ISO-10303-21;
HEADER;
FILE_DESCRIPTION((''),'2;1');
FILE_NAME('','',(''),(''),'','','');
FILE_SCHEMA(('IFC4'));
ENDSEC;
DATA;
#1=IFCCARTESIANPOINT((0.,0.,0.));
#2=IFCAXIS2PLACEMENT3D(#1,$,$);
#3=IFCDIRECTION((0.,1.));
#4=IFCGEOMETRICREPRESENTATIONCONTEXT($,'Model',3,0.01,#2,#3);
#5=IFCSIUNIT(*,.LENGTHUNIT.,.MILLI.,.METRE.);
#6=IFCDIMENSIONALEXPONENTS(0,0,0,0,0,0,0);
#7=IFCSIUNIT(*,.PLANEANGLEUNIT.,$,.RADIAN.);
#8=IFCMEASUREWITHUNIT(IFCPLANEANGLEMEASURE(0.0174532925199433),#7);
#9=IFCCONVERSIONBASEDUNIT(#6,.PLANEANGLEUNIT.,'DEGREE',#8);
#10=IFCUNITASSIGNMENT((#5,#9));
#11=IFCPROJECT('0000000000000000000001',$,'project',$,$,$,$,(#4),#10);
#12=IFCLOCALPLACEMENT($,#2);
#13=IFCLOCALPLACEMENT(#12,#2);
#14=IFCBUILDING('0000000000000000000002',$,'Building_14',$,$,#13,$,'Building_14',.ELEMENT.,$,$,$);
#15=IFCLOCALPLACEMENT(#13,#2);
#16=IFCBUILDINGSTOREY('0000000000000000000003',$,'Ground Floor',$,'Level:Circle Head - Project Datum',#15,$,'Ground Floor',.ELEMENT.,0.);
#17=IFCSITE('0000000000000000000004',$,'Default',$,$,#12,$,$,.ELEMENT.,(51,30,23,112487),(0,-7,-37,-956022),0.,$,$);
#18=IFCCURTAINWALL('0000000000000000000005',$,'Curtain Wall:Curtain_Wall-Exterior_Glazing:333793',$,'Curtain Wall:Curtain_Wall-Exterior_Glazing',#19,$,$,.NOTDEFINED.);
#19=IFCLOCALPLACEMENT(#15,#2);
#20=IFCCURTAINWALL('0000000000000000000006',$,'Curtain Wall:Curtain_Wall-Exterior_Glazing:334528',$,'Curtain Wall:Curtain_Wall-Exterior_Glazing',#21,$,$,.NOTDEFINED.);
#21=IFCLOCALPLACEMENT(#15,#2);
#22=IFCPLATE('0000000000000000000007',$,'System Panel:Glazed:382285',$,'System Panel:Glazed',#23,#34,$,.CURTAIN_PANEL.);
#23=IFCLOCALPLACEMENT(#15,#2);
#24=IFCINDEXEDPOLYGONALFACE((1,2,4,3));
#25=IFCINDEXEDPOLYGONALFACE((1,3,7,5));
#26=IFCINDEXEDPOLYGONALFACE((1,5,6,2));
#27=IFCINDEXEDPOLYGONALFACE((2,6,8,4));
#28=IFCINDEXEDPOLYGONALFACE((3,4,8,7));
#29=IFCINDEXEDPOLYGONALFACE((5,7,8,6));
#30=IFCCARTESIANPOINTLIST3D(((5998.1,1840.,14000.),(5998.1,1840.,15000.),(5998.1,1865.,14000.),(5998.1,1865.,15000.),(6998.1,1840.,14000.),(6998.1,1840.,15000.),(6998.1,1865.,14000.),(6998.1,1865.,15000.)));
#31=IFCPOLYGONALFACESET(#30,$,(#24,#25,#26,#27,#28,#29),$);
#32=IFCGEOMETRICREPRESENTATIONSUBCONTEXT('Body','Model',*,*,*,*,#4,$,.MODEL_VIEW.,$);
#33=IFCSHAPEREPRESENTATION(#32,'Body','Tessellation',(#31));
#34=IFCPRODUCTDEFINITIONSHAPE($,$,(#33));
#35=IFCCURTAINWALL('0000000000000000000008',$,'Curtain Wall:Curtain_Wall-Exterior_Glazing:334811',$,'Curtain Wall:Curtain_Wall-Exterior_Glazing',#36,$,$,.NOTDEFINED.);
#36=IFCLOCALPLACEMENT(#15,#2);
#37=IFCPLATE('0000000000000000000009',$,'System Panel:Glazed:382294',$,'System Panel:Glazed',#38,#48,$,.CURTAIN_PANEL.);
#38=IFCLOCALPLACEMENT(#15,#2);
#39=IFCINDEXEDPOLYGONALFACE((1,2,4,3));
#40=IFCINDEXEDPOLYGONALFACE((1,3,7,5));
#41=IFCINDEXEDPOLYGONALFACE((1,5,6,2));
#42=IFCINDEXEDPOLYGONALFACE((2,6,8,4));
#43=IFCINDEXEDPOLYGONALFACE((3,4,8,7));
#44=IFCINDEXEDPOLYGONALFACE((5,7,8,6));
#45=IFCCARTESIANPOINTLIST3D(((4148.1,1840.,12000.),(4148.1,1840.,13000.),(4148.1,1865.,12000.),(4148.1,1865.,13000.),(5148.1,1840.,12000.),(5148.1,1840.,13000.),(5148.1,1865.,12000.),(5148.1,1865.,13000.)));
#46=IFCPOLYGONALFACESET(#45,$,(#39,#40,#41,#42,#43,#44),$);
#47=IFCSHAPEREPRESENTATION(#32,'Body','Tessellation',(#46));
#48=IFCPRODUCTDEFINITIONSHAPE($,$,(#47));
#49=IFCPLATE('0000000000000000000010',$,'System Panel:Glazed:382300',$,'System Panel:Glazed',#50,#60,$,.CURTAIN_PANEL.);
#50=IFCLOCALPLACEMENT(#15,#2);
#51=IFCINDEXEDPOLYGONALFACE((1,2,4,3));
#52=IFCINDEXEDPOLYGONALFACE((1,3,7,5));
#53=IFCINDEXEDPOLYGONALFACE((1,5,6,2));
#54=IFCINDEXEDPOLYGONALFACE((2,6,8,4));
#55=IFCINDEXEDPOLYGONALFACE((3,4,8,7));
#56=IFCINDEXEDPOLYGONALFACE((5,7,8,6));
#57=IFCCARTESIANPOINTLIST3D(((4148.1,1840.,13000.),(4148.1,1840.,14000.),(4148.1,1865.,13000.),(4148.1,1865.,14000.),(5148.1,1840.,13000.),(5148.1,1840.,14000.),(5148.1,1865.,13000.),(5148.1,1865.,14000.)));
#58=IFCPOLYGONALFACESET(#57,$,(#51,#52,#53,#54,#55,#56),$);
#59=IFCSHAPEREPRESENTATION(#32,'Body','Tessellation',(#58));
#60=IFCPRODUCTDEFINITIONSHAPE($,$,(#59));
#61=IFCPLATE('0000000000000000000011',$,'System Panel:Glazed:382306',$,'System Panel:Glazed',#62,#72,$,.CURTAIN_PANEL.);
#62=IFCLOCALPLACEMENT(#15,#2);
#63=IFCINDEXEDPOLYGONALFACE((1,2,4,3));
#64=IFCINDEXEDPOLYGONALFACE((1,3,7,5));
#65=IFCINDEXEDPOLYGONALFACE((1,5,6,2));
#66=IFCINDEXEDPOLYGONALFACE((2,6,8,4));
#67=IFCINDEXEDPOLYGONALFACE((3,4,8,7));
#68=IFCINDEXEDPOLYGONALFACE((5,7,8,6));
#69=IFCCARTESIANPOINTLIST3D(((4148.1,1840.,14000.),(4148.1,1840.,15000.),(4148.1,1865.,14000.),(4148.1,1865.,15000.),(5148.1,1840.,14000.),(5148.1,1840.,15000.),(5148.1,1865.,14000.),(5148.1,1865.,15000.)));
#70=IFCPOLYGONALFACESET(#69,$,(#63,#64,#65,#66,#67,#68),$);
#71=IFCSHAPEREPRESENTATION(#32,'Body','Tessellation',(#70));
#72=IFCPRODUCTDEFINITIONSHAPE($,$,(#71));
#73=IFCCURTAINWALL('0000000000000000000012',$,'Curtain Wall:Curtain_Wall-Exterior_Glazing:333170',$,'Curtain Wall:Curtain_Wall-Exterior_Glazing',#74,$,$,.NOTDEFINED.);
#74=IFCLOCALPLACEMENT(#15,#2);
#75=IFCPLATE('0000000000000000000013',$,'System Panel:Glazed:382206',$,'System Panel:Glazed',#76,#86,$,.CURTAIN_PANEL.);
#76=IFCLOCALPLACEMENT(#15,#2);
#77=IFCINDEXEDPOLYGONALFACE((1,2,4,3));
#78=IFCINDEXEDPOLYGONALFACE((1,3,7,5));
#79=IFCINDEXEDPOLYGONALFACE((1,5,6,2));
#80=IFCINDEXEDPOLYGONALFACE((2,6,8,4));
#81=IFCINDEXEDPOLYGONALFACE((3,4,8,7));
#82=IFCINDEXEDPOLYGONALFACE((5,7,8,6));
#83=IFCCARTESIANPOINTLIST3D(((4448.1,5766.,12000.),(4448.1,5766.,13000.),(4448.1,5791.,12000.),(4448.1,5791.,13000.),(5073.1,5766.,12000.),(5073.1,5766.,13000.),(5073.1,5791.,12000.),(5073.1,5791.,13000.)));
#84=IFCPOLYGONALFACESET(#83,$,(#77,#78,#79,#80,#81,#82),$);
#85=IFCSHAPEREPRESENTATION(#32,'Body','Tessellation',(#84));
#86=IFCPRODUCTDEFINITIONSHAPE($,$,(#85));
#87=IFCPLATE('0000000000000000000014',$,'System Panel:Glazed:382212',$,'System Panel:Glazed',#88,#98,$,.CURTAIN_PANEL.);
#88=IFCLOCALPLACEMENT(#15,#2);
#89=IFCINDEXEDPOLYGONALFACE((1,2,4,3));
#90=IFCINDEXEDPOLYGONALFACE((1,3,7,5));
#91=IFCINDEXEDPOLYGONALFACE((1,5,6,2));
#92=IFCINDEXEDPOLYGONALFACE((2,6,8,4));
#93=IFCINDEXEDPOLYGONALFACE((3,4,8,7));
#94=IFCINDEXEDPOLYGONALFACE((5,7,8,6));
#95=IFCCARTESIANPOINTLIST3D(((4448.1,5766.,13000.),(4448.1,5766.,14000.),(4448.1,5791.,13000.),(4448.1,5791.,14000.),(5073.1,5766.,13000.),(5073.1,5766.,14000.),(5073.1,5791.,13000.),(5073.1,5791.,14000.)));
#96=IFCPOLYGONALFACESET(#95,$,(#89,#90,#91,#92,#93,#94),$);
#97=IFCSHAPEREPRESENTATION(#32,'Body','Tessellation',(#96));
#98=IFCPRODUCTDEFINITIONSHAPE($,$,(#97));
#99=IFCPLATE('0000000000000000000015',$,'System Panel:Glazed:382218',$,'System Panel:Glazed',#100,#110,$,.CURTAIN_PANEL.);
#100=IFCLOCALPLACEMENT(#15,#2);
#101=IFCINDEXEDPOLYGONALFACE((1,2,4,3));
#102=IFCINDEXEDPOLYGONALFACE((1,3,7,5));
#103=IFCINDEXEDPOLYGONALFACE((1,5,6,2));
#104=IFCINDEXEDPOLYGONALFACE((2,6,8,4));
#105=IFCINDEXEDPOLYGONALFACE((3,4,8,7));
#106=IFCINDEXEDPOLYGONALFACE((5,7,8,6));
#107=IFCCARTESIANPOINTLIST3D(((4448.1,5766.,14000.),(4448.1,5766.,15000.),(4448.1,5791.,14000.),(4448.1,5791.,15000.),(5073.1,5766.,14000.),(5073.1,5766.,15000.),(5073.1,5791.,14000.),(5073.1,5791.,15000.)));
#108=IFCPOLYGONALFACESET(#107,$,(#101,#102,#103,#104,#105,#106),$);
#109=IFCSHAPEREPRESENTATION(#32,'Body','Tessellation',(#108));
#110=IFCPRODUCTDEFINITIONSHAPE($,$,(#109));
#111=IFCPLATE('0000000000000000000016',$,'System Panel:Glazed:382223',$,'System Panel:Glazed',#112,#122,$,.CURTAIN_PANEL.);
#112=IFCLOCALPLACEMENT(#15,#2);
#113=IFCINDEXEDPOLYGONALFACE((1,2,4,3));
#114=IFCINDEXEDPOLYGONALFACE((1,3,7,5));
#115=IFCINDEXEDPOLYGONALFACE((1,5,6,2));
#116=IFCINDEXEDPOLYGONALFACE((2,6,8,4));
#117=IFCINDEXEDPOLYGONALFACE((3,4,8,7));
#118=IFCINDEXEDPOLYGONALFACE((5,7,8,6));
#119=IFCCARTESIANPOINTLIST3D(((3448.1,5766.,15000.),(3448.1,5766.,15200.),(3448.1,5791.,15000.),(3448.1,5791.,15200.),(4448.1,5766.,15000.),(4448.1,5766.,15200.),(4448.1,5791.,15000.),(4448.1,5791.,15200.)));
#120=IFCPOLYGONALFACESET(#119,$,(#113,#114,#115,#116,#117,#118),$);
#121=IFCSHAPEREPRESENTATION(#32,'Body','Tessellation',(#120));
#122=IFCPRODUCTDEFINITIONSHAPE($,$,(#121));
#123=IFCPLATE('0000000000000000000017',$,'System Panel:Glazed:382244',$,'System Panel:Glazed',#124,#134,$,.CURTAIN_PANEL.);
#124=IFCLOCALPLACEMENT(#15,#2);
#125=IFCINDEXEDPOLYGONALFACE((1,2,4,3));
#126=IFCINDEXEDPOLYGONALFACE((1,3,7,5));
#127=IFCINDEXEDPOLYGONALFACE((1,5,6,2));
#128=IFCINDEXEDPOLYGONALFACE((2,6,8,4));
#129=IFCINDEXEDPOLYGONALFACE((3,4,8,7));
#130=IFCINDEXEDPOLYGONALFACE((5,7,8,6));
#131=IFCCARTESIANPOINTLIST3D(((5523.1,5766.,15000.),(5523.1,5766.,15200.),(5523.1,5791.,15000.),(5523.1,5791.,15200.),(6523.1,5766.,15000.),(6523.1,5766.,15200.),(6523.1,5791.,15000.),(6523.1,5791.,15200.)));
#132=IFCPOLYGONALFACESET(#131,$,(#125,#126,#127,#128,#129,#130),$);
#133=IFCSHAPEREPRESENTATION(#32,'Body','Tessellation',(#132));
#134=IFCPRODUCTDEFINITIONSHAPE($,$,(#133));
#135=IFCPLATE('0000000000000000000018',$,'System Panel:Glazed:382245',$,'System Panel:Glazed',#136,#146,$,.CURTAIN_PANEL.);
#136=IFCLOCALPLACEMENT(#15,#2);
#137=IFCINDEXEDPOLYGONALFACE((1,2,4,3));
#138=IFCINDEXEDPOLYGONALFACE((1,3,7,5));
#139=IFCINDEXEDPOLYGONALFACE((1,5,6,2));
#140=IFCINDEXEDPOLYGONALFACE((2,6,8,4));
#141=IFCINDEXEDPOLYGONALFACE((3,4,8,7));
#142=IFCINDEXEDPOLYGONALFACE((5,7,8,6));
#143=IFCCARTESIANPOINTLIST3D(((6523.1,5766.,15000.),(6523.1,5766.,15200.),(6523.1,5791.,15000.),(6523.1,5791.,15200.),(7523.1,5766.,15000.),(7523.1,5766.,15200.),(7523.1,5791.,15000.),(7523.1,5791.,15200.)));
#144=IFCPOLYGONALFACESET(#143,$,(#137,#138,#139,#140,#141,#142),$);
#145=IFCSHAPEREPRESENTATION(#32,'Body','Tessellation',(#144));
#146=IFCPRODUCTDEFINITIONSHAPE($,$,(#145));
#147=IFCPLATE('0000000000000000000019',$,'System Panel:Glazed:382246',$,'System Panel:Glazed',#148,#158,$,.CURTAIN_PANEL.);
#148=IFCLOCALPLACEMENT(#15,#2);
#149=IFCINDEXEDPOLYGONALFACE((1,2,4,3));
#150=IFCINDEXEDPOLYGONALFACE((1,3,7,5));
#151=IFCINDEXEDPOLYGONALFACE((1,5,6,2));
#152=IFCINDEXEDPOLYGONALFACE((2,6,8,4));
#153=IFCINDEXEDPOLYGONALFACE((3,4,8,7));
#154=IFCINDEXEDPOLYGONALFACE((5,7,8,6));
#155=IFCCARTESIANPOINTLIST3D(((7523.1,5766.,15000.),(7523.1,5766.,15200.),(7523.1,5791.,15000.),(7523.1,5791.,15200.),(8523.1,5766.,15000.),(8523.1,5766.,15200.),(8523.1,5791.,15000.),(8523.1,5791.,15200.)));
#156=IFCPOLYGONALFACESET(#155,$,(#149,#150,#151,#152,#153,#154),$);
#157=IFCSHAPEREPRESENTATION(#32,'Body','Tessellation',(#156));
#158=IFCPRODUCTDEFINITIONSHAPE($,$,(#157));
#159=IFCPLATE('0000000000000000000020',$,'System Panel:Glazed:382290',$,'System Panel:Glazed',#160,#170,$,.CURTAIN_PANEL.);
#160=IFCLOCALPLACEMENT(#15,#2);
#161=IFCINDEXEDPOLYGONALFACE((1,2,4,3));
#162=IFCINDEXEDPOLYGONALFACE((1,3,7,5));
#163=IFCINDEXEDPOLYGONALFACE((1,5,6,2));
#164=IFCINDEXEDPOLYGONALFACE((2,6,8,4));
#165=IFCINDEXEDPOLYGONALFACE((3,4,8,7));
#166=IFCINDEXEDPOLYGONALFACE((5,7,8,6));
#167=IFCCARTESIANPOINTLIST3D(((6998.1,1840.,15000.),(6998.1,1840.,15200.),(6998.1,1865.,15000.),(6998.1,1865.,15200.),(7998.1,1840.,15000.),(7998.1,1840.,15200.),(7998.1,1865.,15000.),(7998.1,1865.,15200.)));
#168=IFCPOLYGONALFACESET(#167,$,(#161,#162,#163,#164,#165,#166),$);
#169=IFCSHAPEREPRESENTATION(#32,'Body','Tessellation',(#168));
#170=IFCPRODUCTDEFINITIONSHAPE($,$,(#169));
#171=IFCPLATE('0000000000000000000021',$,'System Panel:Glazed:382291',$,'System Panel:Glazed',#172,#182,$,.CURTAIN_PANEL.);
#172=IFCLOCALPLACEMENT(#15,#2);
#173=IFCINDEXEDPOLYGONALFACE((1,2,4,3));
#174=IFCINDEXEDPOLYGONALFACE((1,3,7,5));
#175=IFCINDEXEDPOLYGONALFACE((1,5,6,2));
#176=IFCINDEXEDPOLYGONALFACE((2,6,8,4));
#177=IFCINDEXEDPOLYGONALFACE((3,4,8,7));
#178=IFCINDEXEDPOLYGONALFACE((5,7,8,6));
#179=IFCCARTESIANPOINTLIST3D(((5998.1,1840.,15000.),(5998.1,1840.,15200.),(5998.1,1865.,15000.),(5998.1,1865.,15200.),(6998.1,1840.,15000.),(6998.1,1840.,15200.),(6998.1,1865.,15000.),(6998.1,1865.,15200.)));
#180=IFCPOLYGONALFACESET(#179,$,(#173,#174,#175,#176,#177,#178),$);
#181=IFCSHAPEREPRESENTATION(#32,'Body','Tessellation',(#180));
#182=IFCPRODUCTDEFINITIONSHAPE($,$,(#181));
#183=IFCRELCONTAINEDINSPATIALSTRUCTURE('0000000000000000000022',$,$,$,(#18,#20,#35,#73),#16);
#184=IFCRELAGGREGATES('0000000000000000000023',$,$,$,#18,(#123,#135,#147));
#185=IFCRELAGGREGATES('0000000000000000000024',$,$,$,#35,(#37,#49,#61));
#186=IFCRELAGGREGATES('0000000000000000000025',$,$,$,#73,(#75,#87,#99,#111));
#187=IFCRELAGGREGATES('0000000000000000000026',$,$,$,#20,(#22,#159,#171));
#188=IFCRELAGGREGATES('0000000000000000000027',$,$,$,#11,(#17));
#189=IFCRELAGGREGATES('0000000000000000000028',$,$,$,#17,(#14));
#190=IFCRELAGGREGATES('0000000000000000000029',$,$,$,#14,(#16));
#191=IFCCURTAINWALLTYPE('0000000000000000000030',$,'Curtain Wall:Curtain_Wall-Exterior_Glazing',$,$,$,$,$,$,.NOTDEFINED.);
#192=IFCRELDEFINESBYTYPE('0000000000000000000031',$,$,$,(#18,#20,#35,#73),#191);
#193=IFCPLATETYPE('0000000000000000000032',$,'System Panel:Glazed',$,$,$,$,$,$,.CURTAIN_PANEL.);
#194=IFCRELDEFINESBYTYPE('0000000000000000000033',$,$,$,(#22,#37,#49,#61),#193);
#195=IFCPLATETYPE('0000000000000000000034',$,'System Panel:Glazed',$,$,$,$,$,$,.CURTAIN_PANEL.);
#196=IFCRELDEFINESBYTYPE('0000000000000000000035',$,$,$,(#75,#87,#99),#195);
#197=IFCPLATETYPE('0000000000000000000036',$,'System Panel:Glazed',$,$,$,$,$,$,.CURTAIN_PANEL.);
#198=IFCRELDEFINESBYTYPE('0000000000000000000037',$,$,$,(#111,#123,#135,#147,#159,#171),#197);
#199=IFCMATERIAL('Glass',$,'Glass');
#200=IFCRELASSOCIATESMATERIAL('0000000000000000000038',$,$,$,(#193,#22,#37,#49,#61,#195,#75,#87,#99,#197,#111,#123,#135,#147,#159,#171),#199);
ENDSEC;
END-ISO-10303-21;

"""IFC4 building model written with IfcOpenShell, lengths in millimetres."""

from ifc_helpers import new_model, entity, si_unit, converted_unit, direction, frame, origin, place, context, subcontext, project, spatial, indexed_curve, outline, extrude, source, transform, mapped, material, type_object, type_shapes, element, aggregate, save


model = new_model("IFC4")

# Units and contexts
model_context = context("Model", 3, precision=0.01, world=origin(), true_north=direction((0.0, 1.0)))
body_context = subcontext(model_context, "Body", "Model", "MODEL_VIEW")
ifc_project = project(units=[si_unit("LENGTHUNIT", "METRE", prefix="MILLI"), converted_unit("PLANEANGLEUNIT", "DEGREE", entity("IfcPlaneAngleMeasure", 0.0174532925199433), si_unit("PLANEANGLEUNIT", "RADIAN"), dimensions=[0, 0, 0, 0, 0, 0, 0])], contexts=[model_context])

# Site, building, storey
site_placement = place(None, origin())
site = spatial("IfcSite", under=ifc_project, at=site_placement, Name="Default", CompositionType="ELEMENT", RefLatitude=(51, 30, 23, 112487), RefLongitude=(0, -7, -37, -956022), RefElevation=0.0)
building_placement = place(site_placement, origin())
building = spatial("IfcBuilding", under=site, at=building_placement, Name="Building_14", LongName="Building_14", CompositionType="ELEMENT")
storey_placement = place(building_placement, origin())
storey = spatial("IfcBuildingStorey", under=building, at=storey_placement, Name="Ground Floor", ObjectType="Level:Circle Head - Project Datum", LongName="Ground Floor", CompositionType="ELEMENT", Elevation=0.0)

# Curtain walls, plates
curtain_wall_type = type_object("IfcCurtainWallType", Name="Curtain Wall:Curtain_Wall-Exterior_Glazing", PredefinedType="NOTDEFINED")
curtain_wall_1_placement = place(storey_placement, origin())
curtain_wall_1 = element("IfcCurtainWall", 1, at=curtain_wall_1_placement, inside=storey, type_object=curtain_wall_type, Name="Curtain Wall:Curtain_Wall-Exterior_Glazing:333793", ObjectType="Curtain Wall:Curtain_Wall-Exterior_Glazing", PredefinedType="NOTDEFINED")
ifc_material = material(Name="Glass", Category="Glass")
plate_type_1 = type_object("IfcPlateType", Name="System Panel:Glazed", PredefinedType="CURTAIN_PANEL", material=ifc_material)
shared_shape_1 = source(origin(), body_context, "Body", "SweptSolid", [
    extrude(outline(indexed_curve([(-12.5, -500.0), (12.5, -500.0), (12.5, 500.0), (-12.5, 500.0), (-12.5, -500.0)], self_intersect=False)), frame((0.0, -37.0, 0.0), z_axis=(0.0, 0.0, 1.0), x_axis=(0.0, 1.0, 0.0)), (0.0, 0.0, 1.0), 1000.0),
])
type_shapes(plate_type_1, [shared_shape_1])
curtain_wall_2_placement = place(storey_placement, origin())
curtain_wall_2 = element("IfcCurtainWall", 2, at=curtain_wall_2_placement, inside=storey, type_object=curtain_wall_type, Name="Curtain Wall:Curtain_Wall-Exterior_Glazing:334528", ObjectType="Curtain Wall:Curtain_Wall-Exterior_Glazing", PredefinedType="NOTDEFINED")
plate_1_placement = place(curtain_wall_2_placement, frame((6498.1, 1815.5, 14000.0), z_axis=(0.0, 0.0, 1.0), x_axis=(-1.0, 0.0, 0.0)))
plate_1 = element("IfcPlate", 3, at=plate_1_placement, type_object=plate_type_1, material=ifc_material, Name="System Panel:Glazed:382285", ObjectType="System Panel:Glazed", PredefinedType="CURTAIN_PANEL", context=body_context, shape_type="MappedRepresentation", body=[
    mapped(shared_shape_1, transform((0.0, 0.0, 0.0), scale=1.0)),
])
curtain_wall_3_placement = place(storey_placement, origin())
curtain_wall_3 = element("IfcCurtainWall", 4, at=curtain_wall_3_placement, inside=storey, type_object=curtain_wall_type, Name="Curtain Wall:Curtain_Wall-Exterior_Glazing:334811", ObjectType="Curtain Wall:Curtain_Wall-Exterior_Glazing", PredefinedType="NOTDEFINED")
plate_2_placement = place(curtain_wall_3_placement, frame((4648.1, 1815.5, 12000.0), z_axis=(0.0, 0.0, 1.0), x_axis=(-1.0, 0.0, 0.0)))
plate_2 = element("IfcPlate", 5, at=plate_2_placement, type_object=plate_type_1, material=ifc_material, Name="System Panel:Glazed:382294", ObjectType="System Panel:Glazed", PredefinedType="CURTAIN_PANEL", context=body_context, shape_type="MappedRepresentation", body=[
    mapped(shared_shape_1, transform((0.0, 0.0, 0.0), scale=1.0)),
])
plate_3_placement = place(curtain_wall_3_placement, frame((4648.1, 1815.5, 13000.0), z_axis=(0.0, 0.0, 1.0), x_axis=(-1.0, 0.0, 0.0)))
plate_3 = element("IfcPlate", 6, at=plate_3_placement, type_object=plate_type_1, material=ifc_material, Name="System Panel:Glazed:382300", ObjectType="System Panel:Glazed", PredefinedType="CURTAIN_PANEL", context=body_context, shape_type="MappedRepresentation", body=[
    mapped(shared_shape_1, transform((0.0, 0.0, 0.0), scale=1.0)),
])
plate_4_placement = place(curtain_wall_3_placement, frame((4648.1, 1815.5, 14000.0), z_axis=(0.0, 0.0, 1.0), x_axis=(-1.0, 0.0, 0.0)))
plate_4 = element("IfcPlate", 7, at=plate_4_placement, type_object=plate_type_1, material=ifc_material, Name="System Panel:Glazed:382306", ObjectType="System Panel:Glazed", PredefinedType="CURTAIN_PANEL", context=body_context, shape_type="MappedRepresentation", body=[
    mapped(shared_shape_1, transform((0.0, 0.0, 0.0), scale=1.0)),
])
curtain_wall_4_placement = place(storey_placement, origin())
curtain_wall_4 = element("IfcCurtainWall", 8, at=curtain_wall_4_placement, inside=storey, type_object=curtain_wall_type, Name="Curtain Wall:Curtain_Wall-Exterior_Glazing:333170", ObjectType="Curtain Wall:Curtain_Wall-Exterior_Glazing", PredefinedType="NOTDEFINED")
plate_type_2 = type_object("IfcPlateType", Name="System Panel:Glazed", PredefinedType="CURTAIN_PANEL", material=ifc_material)
shared_shape_2 = source(origin(), body_context, "Body", "SweptSolid", [
    extrude(outline(indexed_curve([(-12.5, -312.5), (12.5, -312.5), (12.5, 312.5), (-12.5, 312.5), (-12.5, -312.5)], self_intersect=False)), frame((0.0, -37.0, 0.0), z_axis=(0.0, 0.0, 1.0), x_axis=(0.0, 1.0, 0.0)), (0.0, 0.0, 1.0), 1000.0),
])
type_shapes(plate_type_2, [shared_shape_2])
plate_5_placement = place(curtain_wall_4_placement, frame((4760.6, 5815.5, 12000.0)))
plate_5 = element("IfcPlate", 9, at=plate_5_placement, type_object=plate_type_2, material=ifc_material, Name="System Panel:Glazed:382206", ObjectType="System Panel:Glazed", PredefinedType="CURTAIN_PANEL", context=body_context, shape_type="MappedRepresentation", body=[
    mapped(shared_shape_2, transform((0.0, 0.0, 0.0), scale=1.0)),
])
plate_6_placement = place(curtain_wall_4_placement, frame((4760.6, 5815.5, 13000.0)))
plate_6 = element("IfcPlate", 10, at=plate_6_placement, type_object=plate_type_2, material=ifc_material, Name="System Panel:Glazed:382212", ObjectType="System Panel:Glazed", PredefinedType="CURTAIN_PANEL", context=body_context, shape_type="MappedRepresentation", body=[
    mapped(shared_shape_2, transform((0.0, 0.0, 0.0), scale=1.0)),
])
plate_7_placement = place(curtain_wall_4_placement, frame((4760.6, 5815.5, 14000.0)))
plate_7 = element("IfcPlate", 11, at=plate_7_placement, type_object=plate_type_2, material=ifc_material, Name="System Panel:Glazed:382218", ObjectType="System Panel:Glazed", PredefinedType="CURTAIN_PANEL", context=body_context, shape_type="MappedRepresentation", body=[
    mapped(shared_shape_2, transform((0.0, 0.0, 0.0), scale=1.0)),
])
plate_type_3 = type_object("IfcPlateType", Name="System Panel:Glazed", PredefinedType="CURTAIN_PANEL", material=ifc_material)
shared_shape_3 = source(origin(), body_context, "Body", "SweptSolid", [
    extrude(outline(indexed_curve([(-12.5, -500.0), (12.5, -500.0), (12.5, 500.0), (-12.5, 500.0), (-12.5, -500.0)], self_intersect=False)), frame((0.0, -37.0, 0.0), z_axis=(0.0, 0.0, 1.0), x_axis=(0.0, 1.0, 0.0)), (0.0, 0.0, 1.0), 200.0),
])
type_shapes(plate_type_3, [shared_shape_3])
plate_8_placement = place(curtain_wall_4_placement, frame((3948.1, 5815.5, 15000.0)))
plate_8 = element("IfcPlate", 12, at=plate_8_placement, type_object=plate_type_3, material=ifc_material, Name="System Panel:Glazed:382223", ObjectType="System Panel:Glazed", PredefinedType="CURTAIN_PANEL", context=body_context, shape_type="MappedRepresentation", body=[
    mapped(shared_shape_3, transform((0.0, 0.0, 0.0), scale=1.0)),
])

# Plates
plate_9_placement = place(curtain_wall_1_placement, frame((6023.1, 5815.5, 15000.0)))
plate_9 = element("IfcPlate", 13, at=plate_9_placement, type_object=plate_type_3, material=ifc_material, Name="System Panel:Glazed:382244", ObjectType="System Panel:Glazed", PredefinedType="CURTAIN_PANEL", context=body_context, shape_type="MappedRepresentation", body=[
    mapped(shared_shape_3, transform((0.0, 0.0, 0.0), scale=1.0)),
])
plate_10_placement = place(curtain_wall_1_placement, frame((7023.1, 5815.5, 15000.0)))
plate_10 = element("IfcPlate", 14, at=plate_10_placement, type_object=plate_type_3, material=ifc_material, Name="System Panel:Glazed:382245", ObjectType="System Panel:Glazed", PredefinedType="CURTAIN_PANEL", context=body_context, shape_type="MappedRepresentation", body=[
    mapped(shared_shape_3, transform((0.0, 0.0, 0.0), scale=1.0)),
])
plate_11_placement = place(curtain_wall_1_placement, frame((8023.1, 5815.5, 15000.0)))
plate_11 = element("IfcPlate", 15, at=plate_11_placement, type_object=plate_type_3, material=ifc_material, Name="System Panel:Glazed:382246", ObjectType="System Panel:Glazed", PredefinedType="CURTAIN_PANEL", context=body_context, shape_type="MappedRepresentation", body=[
    mapped(shared_shape_3, transform((0.0, 0.0, 0.0), scale=1.0)),
])
aggregate(curtain_wall_1, [plate_9, plate_10, plate_11])
plate_12_placement = place(curtain_wall_2_placement, frame((7498.1, 1815.5, 15000.0), z_axis=(0.0, 0.0, 1.0), x_axis=(-1.0, 0.0, 0.0)))
plate_12 = element("IfcPlate", 16, at=plate_12_placement, type_object=plate_type_3, material=ifc_material, Name="System Panel:Glazed:382290", ObjectType="System Panel:Glazed", PredefinedType="CURTAIN_PANEL", context=body_context, shape_type="MappedRepresentation", body=[
    mapped(shared_shape_3, transform((0.0, 0.0, 0.0), scale=1.0)),
])
plate_13_placement = place(curtain_wall_2_placement, frame((6498.1, 1815.5, 15000.0), z_axis=(0.0, 0.0, 1.0), x_axis=(-1.0, 0.0, 0.0)))
plate_13 = element("IfcPlate", 17, at=plate_13_placement, type_object=plate_type_3, material=ifc_material, Name="System Panel:Glazed:382291", ObjectType="System Panel:Glazed", PredefinedType="CURTAIN_PANEL", context=body_context, shape_type="MappedRepresentation", body=[
    mapped(shared_shape_3, transform((0.0, 0.0, 0.0), scale=1.0)),
])
aggregate(curtain_wall_3, [plate_2, plate_3, plate_4])
aggregate(curtain_wall_4, [plate_5, plate_6, plate_7, plate_8])
aggregate(curtain_wall_2, [plate_1, plate_12, plate_13])

save(model, "model.ifc")
